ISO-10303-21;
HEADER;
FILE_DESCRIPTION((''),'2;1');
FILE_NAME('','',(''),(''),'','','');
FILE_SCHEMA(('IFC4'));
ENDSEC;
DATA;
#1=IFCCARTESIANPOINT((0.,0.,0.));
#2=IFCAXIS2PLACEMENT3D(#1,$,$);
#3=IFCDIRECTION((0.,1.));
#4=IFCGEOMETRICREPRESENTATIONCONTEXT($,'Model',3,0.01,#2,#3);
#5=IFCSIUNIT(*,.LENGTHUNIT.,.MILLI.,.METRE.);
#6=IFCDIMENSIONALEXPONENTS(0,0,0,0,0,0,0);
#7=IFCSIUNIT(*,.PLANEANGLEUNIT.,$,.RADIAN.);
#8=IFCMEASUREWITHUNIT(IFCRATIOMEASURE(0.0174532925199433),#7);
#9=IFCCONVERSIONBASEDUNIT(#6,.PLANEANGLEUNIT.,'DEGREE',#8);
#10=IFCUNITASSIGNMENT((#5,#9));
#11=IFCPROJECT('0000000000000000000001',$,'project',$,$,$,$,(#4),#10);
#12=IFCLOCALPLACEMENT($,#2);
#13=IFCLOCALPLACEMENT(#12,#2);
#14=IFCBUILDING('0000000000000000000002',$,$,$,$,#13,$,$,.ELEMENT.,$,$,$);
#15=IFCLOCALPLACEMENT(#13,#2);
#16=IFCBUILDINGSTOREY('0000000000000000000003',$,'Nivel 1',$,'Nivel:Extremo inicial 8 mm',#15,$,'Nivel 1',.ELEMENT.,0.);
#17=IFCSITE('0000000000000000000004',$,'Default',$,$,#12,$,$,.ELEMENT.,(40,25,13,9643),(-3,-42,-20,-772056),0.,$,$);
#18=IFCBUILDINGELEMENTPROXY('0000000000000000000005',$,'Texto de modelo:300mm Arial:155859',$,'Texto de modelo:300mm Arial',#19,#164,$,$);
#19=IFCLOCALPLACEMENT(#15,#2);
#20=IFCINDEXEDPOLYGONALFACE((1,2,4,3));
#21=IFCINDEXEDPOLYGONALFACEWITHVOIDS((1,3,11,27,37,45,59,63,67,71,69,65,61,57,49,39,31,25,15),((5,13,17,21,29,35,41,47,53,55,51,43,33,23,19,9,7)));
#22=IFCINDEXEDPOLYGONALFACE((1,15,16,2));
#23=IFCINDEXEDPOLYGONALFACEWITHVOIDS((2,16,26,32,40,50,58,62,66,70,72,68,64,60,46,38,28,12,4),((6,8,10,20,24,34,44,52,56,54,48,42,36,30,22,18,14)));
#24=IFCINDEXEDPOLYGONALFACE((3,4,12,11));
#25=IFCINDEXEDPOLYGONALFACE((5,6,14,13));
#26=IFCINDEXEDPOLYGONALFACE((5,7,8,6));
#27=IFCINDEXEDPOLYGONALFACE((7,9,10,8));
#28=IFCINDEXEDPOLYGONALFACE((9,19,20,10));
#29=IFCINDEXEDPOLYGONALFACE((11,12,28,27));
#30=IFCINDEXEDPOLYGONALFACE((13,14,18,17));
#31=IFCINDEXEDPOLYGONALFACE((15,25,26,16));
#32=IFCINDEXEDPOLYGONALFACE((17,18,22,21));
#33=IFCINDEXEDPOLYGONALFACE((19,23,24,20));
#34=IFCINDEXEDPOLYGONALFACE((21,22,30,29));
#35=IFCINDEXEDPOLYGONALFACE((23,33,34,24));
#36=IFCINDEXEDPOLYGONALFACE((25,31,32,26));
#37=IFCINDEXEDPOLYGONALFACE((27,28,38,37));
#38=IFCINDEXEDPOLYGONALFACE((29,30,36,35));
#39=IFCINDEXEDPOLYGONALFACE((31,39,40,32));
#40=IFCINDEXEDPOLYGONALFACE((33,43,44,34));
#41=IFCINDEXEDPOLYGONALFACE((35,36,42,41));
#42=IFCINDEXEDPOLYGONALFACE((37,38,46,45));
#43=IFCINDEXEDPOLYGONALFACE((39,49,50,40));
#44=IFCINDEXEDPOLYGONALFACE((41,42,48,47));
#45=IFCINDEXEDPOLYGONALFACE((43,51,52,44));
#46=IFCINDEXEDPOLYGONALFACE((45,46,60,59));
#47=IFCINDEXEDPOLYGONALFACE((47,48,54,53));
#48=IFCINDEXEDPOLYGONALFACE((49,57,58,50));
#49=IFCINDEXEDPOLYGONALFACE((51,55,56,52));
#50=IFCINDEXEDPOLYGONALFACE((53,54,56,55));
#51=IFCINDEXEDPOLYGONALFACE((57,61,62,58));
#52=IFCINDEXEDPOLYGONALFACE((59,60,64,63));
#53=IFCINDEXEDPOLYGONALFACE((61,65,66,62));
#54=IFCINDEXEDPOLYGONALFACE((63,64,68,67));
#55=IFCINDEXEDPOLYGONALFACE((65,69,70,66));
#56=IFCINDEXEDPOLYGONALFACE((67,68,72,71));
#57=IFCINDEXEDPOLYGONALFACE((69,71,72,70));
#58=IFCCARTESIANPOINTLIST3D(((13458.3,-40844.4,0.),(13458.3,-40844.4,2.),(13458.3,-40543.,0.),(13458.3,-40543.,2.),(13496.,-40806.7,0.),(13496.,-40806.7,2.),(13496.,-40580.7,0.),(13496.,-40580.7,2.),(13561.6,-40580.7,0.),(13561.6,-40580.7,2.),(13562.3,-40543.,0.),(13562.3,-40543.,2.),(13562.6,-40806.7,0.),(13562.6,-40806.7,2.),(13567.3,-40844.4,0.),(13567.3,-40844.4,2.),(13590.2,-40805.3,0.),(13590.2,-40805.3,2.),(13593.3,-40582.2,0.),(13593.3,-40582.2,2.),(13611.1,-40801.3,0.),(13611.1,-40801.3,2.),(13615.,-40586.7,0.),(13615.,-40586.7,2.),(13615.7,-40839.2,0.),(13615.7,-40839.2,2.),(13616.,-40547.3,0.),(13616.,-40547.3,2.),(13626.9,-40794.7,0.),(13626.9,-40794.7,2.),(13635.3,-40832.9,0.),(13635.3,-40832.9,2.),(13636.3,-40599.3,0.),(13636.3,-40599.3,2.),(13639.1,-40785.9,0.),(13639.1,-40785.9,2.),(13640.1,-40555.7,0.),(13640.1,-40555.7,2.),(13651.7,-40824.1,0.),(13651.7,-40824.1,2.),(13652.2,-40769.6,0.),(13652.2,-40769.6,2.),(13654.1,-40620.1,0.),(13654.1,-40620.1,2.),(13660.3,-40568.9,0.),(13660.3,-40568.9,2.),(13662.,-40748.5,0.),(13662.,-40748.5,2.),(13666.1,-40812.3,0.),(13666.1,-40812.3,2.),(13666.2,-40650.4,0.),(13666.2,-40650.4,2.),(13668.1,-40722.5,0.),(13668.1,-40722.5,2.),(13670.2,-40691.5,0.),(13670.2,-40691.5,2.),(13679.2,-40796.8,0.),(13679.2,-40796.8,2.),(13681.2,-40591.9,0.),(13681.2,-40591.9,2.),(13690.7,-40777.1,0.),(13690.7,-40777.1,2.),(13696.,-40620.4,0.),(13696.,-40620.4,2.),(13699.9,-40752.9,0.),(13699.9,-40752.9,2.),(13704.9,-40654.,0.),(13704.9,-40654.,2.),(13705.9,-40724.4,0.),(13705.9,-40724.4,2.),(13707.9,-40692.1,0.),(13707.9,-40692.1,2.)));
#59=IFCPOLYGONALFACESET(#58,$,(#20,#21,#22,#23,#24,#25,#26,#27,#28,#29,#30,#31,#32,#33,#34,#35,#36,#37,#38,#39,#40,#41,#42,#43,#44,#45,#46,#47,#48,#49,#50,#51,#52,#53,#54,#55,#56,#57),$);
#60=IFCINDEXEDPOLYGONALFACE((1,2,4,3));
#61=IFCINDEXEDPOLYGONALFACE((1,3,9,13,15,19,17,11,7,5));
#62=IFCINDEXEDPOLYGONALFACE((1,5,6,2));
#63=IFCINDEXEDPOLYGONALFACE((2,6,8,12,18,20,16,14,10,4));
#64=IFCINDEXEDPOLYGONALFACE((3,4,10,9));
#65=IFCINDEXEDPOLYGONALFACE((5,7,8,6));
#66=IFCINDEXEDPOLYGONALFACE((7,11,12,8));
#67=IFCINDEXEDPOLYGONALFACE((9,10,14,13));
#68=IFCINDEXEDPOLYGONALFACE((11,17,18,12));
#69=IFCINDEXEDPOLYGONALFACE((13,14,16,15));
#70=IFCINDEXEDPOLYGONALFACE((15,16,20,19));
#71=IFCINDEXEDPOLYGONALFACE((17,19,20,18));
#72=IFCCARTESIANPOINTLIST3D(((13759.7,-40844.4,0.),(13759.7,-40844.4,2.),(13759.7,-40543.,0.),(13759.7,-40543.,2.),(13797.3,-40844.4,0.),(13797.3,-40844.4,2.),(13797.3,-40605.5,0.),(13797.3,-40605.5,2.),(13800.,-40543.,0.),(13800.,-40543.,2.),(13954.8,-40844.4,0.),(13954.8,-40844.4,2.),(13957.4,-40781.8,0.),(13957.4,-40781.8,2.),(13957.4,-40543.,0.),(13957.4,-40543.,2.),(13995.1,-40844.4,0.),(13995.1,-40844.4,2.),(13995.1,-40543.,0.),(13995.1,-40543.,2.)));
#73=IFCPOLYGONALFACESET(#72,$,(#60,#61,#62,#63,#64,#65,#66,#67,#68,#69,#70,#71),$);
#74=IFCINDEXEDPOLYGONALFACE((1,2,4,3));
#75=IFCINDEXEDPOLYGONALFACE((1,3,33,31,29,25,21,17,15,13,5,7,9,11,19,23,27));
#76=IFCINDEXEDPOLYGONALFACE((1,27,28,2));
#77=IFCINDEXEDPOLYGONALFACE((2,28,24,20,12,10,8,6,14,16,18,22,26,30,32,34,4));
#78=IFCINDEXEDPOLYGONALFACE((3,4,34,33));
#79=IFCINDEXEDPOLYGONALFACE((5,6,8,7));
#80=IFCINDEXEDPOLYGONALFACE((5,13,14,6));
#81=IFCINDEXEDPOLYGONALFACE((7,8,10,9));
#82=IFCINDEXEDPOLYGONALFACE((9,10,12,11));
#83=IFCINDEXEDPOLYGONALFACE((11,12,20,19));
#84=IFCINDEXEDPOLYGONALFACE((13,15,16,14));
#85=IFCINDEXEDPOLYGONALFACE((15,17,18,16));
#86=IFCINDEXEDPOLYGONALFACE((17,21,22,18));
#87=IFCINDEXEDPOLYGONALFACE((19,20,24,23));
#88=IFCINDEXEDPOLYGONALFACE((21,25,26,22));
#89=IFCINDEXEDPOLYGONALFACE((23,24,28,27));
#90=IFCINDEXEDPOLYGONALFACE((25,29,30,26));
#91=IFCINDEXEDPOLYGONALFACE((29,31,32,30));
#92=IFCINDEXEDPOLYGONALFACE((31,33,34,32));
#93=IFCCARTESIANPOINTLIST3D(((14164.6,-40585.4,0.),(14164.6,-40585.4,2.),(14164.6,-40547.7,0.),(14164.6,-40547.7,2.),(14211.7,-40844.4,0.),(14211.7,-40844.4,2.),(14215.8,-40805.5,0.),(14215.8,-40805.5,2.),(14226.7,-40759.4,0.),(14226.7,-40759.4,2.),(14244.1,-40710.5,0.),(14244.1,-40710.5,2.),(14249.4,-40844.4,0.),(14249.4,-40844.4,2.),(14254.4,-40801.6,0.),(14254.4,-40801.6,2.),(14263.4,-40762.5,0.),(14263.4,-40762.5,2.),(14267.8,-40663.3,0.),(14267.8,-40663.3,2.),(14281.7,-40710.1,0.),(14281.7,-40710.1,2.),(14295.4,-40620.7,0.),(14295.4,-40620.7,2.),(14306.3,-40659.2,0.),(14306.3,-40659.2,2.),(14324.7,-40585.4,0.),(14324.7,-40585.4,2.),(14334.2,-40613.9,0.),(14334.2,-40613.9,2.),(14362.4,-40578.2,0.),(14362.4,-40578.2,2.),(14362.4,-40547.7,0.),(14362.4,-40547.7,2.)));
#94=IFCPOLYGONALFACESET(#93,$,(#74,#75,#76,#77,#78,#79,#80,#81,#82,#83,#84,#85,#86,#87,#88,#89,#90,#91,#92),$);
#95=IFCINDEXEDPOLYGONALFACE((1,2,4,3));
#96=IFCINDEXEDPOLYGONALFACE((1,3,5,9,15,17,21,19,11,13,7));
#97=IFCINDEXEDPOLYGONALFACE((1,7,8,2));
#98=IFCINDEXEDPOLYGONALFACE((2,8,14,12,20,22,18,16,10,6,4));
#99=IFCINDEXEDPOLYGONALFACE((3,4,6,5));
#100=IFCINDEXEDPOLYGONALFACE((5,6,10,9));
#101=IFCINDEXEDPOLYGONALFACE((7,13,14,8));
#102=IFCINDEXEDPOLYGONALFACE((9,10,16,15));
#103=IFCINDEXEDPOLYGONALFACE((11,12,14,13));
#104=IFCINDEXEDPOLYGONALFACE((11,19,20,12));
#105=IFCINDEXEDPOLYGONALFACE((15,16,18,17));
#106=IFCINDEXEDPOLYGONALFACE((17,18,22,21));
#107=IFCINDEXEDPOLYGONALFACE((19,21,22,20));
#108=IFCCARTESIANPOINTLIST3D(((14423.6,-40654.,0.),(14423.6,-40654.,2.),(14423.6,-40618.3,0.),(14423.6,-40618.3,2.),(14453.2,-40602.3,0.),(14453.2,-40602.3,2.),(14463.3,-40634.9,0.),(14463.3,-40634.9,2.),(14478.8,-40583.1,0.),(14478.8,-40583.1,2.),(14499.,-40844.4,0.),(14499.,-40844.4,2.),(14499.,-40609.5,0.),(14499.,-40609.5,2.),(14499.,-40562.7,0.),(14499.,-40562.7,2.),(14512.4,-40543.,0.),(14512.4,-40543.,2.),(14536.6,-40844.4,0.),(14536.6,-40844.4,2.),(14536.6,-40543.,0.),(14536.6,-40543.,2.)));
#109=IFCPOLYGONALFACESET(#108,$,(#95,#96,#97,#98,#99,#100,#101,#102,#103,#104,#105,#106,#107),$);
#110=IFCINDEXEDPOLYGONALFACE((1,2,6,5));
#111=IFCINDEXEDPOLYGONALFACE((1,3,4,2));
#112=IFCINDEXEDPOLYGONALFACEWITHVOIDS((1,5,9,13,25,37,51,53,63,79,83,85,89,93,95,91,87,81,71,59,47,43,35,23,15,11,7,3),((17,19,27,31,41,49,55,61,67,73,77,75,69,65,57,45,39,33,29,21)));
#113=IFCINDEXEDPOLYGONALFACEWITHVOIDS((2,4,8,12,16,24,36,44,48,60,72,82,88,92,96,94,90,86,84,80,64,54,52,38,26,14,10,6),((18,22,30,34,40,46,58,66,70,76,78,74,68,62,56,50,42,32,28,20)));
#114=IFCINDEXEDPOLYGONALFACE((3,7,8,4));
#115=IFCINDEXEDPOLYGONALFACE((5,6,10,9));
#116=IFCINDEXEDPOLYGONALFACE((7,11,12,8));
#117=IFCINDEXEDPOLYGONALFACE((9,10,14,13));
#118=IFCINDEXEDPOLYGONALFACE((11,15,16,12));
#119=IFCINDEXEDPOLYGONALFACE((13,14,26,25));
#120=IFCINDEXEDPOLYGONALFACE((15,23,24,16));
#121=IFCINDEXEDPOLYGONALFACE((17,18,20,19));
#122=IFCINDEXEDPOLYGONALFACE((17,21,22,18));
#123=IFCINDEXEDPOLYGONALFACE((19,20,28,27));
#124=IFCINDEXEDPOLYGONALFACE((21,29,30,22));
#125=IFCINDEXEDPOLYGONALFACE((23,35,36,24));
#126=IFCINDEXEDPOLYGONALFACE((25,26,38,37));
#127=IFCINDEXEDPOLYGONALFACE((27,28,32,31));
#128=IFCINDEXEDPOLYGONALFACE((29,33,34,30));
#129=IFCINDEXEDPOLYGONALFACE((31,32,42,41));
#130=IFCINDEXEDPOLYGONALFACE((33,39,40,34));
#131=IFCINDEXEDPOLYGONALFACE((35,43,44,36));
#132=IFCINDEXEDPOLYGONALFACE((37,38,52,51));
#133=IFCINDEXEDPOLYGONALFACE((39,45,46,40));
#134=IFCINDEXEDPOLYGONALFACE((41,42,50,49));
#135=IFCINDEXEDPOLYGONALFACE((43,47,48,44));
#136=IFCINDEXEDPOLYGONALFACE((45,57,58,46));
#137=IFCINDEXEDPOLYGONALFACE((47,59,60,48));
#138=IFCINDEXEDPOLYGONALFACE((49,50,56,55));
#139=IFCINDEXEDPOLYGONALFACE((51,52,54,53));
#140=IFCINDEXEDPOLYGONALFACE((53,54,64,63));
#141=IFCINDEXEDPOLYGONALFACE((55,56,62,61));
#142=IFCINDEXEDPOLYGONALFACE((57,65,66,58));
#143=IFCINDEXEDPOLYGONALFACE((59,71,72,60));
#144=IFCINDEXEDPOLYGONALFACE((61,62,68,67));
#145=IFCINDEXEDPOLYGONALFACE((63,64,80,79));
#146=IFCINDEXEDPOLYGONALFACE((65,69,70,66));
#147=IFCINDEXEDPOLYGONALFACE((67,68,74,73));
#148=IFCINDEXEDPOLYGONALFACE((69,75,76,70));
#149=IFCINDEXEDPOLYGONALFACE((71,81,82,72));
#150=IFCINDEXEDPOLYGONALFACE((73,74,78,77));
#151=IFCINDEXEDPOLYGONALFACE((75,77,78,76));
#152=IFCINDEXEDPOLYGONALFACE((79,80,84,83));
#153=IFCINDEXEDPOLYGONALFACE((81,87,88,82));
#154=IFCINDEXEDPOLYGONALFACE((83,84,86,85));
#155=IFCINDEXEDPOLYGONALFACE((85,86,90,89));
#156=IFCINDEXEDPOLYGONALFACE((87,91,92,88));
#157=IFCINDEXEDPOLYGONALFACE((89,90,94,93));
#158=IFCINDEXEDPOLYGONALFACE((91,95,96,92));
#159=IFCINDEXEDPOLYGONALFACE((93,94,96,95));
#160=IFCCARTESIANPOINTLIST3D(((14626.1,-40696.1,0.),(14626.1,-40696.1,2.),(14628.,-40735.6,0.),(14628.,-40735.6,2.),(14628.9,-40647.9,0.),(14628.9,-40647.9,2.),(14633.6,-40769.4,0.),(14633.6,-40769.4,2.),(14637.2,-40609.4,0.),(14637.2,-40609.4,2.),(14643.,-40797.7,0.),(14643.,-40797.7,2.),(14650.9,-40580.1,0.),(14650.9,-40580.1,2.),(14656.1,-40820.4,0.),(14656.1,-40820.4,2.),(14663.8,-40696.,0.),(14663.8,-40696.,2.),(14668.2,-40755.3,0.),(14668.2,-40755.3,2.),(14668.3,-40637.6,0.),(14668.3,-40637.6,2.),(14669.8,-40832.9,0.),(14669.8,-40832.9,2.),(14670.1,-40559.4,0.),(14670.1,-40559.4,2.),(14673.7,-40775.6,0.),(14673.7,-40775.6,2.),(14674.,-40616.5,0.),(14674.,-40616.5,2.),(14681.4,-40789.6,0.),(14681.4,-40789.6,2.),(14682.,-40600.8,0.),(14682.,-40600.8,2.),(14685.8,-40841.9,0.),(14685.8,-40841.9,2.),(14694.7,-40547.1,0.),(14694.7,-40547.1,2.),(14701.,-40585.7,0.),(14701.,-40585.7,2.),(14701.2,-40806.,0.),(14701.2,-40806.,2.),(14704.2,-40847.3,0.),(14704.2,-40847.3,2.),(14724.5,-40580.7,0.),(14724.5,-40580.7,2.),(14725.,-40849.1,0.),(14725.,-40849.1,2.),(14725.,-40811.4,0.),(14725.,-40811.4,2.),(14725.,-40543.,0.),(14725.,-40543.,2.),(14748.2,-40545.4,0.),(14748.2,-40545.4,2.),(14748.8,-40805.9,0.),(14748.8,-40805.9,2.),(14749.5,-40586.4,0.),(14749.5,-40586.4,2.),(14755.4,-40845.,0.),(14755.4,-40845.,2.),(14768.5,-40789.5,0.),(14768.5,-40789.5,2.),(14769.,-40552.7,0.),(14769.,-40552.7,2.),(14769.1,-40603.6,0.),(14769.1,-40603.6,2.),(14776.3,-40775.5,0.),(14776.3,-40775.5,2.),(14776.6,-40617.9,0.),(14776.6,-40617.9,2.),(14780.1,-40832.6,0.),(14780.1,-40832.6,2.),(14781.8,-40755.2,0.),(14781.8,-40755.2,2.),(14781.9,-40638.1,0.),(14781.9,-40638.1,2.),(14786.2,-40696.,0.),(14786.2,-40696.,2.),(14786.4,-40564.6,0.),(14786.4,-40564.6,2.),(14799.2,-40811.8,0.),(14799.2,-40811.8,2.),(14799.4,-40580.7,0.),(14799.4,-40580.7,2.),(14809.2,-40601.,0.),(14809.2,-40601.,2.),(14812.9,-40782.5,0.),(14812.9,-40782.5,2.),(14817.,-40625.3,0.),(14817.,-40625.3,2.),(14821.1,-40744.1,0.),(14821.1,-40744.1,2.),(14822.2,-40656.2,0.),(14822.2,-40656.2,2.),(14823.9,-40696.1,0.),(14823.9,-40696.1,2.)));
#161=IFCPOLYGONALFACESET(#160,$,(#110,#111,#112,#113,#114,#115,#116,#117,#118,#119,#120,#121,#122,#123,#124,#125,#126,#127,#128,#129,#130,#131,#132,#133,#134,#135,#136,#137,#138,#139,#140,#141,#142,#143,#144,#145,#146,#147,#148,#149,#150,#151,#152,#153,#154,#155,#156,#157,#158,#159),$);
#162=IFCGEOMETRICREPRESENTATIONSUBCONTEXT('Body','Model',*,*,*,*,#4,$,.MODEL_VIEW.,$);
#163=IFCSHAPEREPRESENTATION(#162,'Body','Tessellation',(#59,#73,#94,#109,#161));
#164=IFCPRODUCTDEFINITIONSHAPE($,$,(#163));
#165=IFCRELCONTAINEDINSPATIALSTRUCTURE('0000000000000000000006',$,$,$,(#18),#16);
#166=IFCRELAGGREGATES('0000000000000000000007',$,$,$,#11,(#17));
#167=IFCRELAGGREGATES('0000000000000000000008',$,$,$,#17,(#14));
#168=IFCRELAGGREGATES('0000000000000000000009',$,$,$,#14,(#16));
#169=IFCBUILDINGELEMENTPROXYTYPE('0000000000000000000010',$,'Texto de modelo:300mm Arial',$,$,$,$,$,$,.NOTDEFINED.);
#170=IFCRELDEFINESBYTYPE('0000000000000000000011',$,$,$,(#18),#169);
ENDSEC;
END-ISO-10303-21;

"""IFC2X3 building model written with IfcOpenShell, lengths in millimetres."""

from ifc_helpers import new_model, entity, si_unit, converted_unit, direction, frame, origin, place, context, subcontext, project, spatial, polyline, outline, extrude, type_object, element, save


model = new_model("IFC2X3")

# Units and contexts
model_context = context("Model", 3, precision=0.01, world=origin(), true_north=direction((0.0, 1.0)))
body_context = subcontext(model_context, "Body", "Model", "MODEL_VIEW")
ifc_project = project(units=[si_unit("LENGTHUNIT", "METRE", prefix="MILLI"), converted_unit("PLANEANGLEUNIT", "DEGREE", entity("IfcRatioMeasure", 0.0174532925199433), si_unit("PLANEANGLEUNIT", "RADIAN"), dimensions=[0, 0, 0, 0, 0, 0, 0])], contexts=[model_context])

# Site, building, storey
site_placement = place(None, origin())
site = spatial("IfcSite", under=ifc_project, at=site_placement, Name="Default", CompositionType="ELEMENT", RefLatitude=(40, 25, 13, 9643), RefLongitude=(-3, -42, -20, -772056), RefElevation=0.0)
building_placement = place(site_placement, origin())
building = spatial("IfcBuilding", under=site, at=building_placement, CompositionType="ELEMENT")
storey_placement = place(building_placement, origin())
storey = spatial("IfcBuildingStorey", under=building, at=storey_placement, Name="Nivel 1", ObjectType="Nivel:Extremo inicial 8 mm", LongName="Nivel 1", CompositionType="ELEMENT", Elevation=0.0)

# Building element proxy
building_element_proxy_type_1 = type_object("IfcBuildingElementProxyType", Name="Texto de modelo:300mm Arial", PredefinedType="NOTDEFINED")
proxy_1_placement = place(storey_placement, frame((13458.3, -40849.1, 0.0)))
element("IfcBuildingElementProxy", 1, at=proxy_1_placement, inside=storey, type_object=building_element_proxy_type_1, Name="Texto de modelo:300mm Arial:155859", ObjectType="Texto de modelo:300mm Arial", context=body_context, shape_type="SweptSolid", body=[
    extrude(outline(polyline([(-178.4, -141.0), (-69.4, -141.0), (-21.0, -135.8), (-1.4, -129.5), (15.0, -120.7), (29.4, -108.9), (42.6, -93.4), (54.0, -73.7), (63.2, -49.5), (69.2, -21.0), (71.2, 11.3), (68.2, 49.4), (59.3, 83.0), (44.5, 111.5), (23.7, 134.5), (3.4, 147.7), (-20.6, 156.1), (-74.4, 160.4), (-178.4, 160.4), (-178.4, -141.0)]), holes=[polyline([(-140.7, -103.3), (-140.7, 122.7), (-75.1, 122.7), (-43.3, 121.2), (-21.7, 116.7), (-0.4, 104.1), (17.4, 83.3), (29.5, 53.0), (33.5, 11.9), (31.5, -19.1), (25.3, -45.1), (15.5, -66.2), (2.4, -82.5), (-9.8, -91.3), (-25.6, -97.9), (-46.5, -101.9), (-74.1, -103.3), (-140.7, -103.3)])]), frame((178.4, 145.7, 0.0)), (0.0, 0.0, 1.0), 2.0),
    extrude(outline(polyline([(-117.7, -150.7), (-80.1, -150.7), (-80.1, 88.1), (77.4, -150.7), (117.7, -150.7), (117.7, 150.7), (80.1, 150.7), (80.1, -88.1), (-77.4, 150.7), (-117.7, 150.7), (-117.7, -150.7)])), frame((419.1, 155.4, 0.0)), (0.0, 0.0, 1.0), 2.0),
    extrude(outline(polyline([(-101.8, -99.3), (-101.8, -137.0), (96.0, -137.0), (96.0, -106.5), (67.8, -70.9), (39.9, -25.5), (15.2, 25.4), (-3.1, 77.8), (-12.1, 116.9), (-17.1, 159.7), (-54.7, 159.7), (-50.7, 120.8), (-39.8, 74.7), (-22.3, 25.8), (1.3, -21.4), (29.0, -64.0), (58.3, -99.3), (-101.8, -99.3)])), frame((808.2, 164.4, 0.0), z_axis=(0.0, 0.0, -1.0), x_axis=(1.0, 0.0, 0.0)), (0.0, 0.0, -1.0), 2.0),
    extrude(outline(polyline([(-204.4, -52.5), (97.0, -52.5), (97.0, -28.2), (77.2, -14.9), (56.9, 5.3), (37.7, 30.9), (21.6, 60.5), (-14.0, 60.5), (5.0, 20.8), (30.4, -14.9), (-204.4, -14.9), (-204.4, -52.5)])), frame((1025.8, 209.1, 0.0), z_axis=(0.0, 0.0, 1.0), x_axis=(0.0, 1.0, 0.0)), (0.0, 0.0, 1.0), 2.0),
    extrude(outline(polyline([(-5.6, -99.5), (33.9, -99.5), (68.0, -95.5), (96.7, -87.5), (120.0, -75.5), (133.2, -62.4), (142.9, -46.8), (149.1, -28.7), (151.9, -8.0), (149.2, 22.6), (138.0, 47.8), (118.2, 67.9), (89.5, 82.9), (51.6, 93.0), (3.8, 98.0), (-36.2, 98.2), (-67.3, 94.5), (-91.9, 87.9), (-112.6, 79.0), (-129.4, 66.8), (-142.0, 50.0), (-150.3, 29.6), (-153.8, 6.5), (-151.2, -23.9), (-140.1, -49.1), (-120.3, -69.2), (-91.7, -84.4), (-53.6, -94.5), (-5.6, -99.5)]), holes=[polyline([(-3.9, -61.9), (-62.1, -54.6), (-82.9, -47.9), (-98.1, -39.2), (-112.3, -19.5), (-116.2, 4.3), (-109.3, 28.9), (-91.2, 47.7), (-76.5, 54.5), (-56.1, 58.9), (1.9, 60.4), (60.8, 53.2), (80.8, 46.7), (94.5, 38.3), (109.9, 17.8), (114.3, -6.3), (107.7, -29.8), (90.4, -48.7), (76.0, -55.8), (55.5, -60.3), (-3.9, -61.9)])]), frame((1267.5, 152.1, 0.0), z_axis=(0.0, 0.0, 1.0), x_axis=(0.047515, -0.998871, 0.0)), (0.0, 0.0, 1.0), 2.0),
])

save(model, "model.ifc")
